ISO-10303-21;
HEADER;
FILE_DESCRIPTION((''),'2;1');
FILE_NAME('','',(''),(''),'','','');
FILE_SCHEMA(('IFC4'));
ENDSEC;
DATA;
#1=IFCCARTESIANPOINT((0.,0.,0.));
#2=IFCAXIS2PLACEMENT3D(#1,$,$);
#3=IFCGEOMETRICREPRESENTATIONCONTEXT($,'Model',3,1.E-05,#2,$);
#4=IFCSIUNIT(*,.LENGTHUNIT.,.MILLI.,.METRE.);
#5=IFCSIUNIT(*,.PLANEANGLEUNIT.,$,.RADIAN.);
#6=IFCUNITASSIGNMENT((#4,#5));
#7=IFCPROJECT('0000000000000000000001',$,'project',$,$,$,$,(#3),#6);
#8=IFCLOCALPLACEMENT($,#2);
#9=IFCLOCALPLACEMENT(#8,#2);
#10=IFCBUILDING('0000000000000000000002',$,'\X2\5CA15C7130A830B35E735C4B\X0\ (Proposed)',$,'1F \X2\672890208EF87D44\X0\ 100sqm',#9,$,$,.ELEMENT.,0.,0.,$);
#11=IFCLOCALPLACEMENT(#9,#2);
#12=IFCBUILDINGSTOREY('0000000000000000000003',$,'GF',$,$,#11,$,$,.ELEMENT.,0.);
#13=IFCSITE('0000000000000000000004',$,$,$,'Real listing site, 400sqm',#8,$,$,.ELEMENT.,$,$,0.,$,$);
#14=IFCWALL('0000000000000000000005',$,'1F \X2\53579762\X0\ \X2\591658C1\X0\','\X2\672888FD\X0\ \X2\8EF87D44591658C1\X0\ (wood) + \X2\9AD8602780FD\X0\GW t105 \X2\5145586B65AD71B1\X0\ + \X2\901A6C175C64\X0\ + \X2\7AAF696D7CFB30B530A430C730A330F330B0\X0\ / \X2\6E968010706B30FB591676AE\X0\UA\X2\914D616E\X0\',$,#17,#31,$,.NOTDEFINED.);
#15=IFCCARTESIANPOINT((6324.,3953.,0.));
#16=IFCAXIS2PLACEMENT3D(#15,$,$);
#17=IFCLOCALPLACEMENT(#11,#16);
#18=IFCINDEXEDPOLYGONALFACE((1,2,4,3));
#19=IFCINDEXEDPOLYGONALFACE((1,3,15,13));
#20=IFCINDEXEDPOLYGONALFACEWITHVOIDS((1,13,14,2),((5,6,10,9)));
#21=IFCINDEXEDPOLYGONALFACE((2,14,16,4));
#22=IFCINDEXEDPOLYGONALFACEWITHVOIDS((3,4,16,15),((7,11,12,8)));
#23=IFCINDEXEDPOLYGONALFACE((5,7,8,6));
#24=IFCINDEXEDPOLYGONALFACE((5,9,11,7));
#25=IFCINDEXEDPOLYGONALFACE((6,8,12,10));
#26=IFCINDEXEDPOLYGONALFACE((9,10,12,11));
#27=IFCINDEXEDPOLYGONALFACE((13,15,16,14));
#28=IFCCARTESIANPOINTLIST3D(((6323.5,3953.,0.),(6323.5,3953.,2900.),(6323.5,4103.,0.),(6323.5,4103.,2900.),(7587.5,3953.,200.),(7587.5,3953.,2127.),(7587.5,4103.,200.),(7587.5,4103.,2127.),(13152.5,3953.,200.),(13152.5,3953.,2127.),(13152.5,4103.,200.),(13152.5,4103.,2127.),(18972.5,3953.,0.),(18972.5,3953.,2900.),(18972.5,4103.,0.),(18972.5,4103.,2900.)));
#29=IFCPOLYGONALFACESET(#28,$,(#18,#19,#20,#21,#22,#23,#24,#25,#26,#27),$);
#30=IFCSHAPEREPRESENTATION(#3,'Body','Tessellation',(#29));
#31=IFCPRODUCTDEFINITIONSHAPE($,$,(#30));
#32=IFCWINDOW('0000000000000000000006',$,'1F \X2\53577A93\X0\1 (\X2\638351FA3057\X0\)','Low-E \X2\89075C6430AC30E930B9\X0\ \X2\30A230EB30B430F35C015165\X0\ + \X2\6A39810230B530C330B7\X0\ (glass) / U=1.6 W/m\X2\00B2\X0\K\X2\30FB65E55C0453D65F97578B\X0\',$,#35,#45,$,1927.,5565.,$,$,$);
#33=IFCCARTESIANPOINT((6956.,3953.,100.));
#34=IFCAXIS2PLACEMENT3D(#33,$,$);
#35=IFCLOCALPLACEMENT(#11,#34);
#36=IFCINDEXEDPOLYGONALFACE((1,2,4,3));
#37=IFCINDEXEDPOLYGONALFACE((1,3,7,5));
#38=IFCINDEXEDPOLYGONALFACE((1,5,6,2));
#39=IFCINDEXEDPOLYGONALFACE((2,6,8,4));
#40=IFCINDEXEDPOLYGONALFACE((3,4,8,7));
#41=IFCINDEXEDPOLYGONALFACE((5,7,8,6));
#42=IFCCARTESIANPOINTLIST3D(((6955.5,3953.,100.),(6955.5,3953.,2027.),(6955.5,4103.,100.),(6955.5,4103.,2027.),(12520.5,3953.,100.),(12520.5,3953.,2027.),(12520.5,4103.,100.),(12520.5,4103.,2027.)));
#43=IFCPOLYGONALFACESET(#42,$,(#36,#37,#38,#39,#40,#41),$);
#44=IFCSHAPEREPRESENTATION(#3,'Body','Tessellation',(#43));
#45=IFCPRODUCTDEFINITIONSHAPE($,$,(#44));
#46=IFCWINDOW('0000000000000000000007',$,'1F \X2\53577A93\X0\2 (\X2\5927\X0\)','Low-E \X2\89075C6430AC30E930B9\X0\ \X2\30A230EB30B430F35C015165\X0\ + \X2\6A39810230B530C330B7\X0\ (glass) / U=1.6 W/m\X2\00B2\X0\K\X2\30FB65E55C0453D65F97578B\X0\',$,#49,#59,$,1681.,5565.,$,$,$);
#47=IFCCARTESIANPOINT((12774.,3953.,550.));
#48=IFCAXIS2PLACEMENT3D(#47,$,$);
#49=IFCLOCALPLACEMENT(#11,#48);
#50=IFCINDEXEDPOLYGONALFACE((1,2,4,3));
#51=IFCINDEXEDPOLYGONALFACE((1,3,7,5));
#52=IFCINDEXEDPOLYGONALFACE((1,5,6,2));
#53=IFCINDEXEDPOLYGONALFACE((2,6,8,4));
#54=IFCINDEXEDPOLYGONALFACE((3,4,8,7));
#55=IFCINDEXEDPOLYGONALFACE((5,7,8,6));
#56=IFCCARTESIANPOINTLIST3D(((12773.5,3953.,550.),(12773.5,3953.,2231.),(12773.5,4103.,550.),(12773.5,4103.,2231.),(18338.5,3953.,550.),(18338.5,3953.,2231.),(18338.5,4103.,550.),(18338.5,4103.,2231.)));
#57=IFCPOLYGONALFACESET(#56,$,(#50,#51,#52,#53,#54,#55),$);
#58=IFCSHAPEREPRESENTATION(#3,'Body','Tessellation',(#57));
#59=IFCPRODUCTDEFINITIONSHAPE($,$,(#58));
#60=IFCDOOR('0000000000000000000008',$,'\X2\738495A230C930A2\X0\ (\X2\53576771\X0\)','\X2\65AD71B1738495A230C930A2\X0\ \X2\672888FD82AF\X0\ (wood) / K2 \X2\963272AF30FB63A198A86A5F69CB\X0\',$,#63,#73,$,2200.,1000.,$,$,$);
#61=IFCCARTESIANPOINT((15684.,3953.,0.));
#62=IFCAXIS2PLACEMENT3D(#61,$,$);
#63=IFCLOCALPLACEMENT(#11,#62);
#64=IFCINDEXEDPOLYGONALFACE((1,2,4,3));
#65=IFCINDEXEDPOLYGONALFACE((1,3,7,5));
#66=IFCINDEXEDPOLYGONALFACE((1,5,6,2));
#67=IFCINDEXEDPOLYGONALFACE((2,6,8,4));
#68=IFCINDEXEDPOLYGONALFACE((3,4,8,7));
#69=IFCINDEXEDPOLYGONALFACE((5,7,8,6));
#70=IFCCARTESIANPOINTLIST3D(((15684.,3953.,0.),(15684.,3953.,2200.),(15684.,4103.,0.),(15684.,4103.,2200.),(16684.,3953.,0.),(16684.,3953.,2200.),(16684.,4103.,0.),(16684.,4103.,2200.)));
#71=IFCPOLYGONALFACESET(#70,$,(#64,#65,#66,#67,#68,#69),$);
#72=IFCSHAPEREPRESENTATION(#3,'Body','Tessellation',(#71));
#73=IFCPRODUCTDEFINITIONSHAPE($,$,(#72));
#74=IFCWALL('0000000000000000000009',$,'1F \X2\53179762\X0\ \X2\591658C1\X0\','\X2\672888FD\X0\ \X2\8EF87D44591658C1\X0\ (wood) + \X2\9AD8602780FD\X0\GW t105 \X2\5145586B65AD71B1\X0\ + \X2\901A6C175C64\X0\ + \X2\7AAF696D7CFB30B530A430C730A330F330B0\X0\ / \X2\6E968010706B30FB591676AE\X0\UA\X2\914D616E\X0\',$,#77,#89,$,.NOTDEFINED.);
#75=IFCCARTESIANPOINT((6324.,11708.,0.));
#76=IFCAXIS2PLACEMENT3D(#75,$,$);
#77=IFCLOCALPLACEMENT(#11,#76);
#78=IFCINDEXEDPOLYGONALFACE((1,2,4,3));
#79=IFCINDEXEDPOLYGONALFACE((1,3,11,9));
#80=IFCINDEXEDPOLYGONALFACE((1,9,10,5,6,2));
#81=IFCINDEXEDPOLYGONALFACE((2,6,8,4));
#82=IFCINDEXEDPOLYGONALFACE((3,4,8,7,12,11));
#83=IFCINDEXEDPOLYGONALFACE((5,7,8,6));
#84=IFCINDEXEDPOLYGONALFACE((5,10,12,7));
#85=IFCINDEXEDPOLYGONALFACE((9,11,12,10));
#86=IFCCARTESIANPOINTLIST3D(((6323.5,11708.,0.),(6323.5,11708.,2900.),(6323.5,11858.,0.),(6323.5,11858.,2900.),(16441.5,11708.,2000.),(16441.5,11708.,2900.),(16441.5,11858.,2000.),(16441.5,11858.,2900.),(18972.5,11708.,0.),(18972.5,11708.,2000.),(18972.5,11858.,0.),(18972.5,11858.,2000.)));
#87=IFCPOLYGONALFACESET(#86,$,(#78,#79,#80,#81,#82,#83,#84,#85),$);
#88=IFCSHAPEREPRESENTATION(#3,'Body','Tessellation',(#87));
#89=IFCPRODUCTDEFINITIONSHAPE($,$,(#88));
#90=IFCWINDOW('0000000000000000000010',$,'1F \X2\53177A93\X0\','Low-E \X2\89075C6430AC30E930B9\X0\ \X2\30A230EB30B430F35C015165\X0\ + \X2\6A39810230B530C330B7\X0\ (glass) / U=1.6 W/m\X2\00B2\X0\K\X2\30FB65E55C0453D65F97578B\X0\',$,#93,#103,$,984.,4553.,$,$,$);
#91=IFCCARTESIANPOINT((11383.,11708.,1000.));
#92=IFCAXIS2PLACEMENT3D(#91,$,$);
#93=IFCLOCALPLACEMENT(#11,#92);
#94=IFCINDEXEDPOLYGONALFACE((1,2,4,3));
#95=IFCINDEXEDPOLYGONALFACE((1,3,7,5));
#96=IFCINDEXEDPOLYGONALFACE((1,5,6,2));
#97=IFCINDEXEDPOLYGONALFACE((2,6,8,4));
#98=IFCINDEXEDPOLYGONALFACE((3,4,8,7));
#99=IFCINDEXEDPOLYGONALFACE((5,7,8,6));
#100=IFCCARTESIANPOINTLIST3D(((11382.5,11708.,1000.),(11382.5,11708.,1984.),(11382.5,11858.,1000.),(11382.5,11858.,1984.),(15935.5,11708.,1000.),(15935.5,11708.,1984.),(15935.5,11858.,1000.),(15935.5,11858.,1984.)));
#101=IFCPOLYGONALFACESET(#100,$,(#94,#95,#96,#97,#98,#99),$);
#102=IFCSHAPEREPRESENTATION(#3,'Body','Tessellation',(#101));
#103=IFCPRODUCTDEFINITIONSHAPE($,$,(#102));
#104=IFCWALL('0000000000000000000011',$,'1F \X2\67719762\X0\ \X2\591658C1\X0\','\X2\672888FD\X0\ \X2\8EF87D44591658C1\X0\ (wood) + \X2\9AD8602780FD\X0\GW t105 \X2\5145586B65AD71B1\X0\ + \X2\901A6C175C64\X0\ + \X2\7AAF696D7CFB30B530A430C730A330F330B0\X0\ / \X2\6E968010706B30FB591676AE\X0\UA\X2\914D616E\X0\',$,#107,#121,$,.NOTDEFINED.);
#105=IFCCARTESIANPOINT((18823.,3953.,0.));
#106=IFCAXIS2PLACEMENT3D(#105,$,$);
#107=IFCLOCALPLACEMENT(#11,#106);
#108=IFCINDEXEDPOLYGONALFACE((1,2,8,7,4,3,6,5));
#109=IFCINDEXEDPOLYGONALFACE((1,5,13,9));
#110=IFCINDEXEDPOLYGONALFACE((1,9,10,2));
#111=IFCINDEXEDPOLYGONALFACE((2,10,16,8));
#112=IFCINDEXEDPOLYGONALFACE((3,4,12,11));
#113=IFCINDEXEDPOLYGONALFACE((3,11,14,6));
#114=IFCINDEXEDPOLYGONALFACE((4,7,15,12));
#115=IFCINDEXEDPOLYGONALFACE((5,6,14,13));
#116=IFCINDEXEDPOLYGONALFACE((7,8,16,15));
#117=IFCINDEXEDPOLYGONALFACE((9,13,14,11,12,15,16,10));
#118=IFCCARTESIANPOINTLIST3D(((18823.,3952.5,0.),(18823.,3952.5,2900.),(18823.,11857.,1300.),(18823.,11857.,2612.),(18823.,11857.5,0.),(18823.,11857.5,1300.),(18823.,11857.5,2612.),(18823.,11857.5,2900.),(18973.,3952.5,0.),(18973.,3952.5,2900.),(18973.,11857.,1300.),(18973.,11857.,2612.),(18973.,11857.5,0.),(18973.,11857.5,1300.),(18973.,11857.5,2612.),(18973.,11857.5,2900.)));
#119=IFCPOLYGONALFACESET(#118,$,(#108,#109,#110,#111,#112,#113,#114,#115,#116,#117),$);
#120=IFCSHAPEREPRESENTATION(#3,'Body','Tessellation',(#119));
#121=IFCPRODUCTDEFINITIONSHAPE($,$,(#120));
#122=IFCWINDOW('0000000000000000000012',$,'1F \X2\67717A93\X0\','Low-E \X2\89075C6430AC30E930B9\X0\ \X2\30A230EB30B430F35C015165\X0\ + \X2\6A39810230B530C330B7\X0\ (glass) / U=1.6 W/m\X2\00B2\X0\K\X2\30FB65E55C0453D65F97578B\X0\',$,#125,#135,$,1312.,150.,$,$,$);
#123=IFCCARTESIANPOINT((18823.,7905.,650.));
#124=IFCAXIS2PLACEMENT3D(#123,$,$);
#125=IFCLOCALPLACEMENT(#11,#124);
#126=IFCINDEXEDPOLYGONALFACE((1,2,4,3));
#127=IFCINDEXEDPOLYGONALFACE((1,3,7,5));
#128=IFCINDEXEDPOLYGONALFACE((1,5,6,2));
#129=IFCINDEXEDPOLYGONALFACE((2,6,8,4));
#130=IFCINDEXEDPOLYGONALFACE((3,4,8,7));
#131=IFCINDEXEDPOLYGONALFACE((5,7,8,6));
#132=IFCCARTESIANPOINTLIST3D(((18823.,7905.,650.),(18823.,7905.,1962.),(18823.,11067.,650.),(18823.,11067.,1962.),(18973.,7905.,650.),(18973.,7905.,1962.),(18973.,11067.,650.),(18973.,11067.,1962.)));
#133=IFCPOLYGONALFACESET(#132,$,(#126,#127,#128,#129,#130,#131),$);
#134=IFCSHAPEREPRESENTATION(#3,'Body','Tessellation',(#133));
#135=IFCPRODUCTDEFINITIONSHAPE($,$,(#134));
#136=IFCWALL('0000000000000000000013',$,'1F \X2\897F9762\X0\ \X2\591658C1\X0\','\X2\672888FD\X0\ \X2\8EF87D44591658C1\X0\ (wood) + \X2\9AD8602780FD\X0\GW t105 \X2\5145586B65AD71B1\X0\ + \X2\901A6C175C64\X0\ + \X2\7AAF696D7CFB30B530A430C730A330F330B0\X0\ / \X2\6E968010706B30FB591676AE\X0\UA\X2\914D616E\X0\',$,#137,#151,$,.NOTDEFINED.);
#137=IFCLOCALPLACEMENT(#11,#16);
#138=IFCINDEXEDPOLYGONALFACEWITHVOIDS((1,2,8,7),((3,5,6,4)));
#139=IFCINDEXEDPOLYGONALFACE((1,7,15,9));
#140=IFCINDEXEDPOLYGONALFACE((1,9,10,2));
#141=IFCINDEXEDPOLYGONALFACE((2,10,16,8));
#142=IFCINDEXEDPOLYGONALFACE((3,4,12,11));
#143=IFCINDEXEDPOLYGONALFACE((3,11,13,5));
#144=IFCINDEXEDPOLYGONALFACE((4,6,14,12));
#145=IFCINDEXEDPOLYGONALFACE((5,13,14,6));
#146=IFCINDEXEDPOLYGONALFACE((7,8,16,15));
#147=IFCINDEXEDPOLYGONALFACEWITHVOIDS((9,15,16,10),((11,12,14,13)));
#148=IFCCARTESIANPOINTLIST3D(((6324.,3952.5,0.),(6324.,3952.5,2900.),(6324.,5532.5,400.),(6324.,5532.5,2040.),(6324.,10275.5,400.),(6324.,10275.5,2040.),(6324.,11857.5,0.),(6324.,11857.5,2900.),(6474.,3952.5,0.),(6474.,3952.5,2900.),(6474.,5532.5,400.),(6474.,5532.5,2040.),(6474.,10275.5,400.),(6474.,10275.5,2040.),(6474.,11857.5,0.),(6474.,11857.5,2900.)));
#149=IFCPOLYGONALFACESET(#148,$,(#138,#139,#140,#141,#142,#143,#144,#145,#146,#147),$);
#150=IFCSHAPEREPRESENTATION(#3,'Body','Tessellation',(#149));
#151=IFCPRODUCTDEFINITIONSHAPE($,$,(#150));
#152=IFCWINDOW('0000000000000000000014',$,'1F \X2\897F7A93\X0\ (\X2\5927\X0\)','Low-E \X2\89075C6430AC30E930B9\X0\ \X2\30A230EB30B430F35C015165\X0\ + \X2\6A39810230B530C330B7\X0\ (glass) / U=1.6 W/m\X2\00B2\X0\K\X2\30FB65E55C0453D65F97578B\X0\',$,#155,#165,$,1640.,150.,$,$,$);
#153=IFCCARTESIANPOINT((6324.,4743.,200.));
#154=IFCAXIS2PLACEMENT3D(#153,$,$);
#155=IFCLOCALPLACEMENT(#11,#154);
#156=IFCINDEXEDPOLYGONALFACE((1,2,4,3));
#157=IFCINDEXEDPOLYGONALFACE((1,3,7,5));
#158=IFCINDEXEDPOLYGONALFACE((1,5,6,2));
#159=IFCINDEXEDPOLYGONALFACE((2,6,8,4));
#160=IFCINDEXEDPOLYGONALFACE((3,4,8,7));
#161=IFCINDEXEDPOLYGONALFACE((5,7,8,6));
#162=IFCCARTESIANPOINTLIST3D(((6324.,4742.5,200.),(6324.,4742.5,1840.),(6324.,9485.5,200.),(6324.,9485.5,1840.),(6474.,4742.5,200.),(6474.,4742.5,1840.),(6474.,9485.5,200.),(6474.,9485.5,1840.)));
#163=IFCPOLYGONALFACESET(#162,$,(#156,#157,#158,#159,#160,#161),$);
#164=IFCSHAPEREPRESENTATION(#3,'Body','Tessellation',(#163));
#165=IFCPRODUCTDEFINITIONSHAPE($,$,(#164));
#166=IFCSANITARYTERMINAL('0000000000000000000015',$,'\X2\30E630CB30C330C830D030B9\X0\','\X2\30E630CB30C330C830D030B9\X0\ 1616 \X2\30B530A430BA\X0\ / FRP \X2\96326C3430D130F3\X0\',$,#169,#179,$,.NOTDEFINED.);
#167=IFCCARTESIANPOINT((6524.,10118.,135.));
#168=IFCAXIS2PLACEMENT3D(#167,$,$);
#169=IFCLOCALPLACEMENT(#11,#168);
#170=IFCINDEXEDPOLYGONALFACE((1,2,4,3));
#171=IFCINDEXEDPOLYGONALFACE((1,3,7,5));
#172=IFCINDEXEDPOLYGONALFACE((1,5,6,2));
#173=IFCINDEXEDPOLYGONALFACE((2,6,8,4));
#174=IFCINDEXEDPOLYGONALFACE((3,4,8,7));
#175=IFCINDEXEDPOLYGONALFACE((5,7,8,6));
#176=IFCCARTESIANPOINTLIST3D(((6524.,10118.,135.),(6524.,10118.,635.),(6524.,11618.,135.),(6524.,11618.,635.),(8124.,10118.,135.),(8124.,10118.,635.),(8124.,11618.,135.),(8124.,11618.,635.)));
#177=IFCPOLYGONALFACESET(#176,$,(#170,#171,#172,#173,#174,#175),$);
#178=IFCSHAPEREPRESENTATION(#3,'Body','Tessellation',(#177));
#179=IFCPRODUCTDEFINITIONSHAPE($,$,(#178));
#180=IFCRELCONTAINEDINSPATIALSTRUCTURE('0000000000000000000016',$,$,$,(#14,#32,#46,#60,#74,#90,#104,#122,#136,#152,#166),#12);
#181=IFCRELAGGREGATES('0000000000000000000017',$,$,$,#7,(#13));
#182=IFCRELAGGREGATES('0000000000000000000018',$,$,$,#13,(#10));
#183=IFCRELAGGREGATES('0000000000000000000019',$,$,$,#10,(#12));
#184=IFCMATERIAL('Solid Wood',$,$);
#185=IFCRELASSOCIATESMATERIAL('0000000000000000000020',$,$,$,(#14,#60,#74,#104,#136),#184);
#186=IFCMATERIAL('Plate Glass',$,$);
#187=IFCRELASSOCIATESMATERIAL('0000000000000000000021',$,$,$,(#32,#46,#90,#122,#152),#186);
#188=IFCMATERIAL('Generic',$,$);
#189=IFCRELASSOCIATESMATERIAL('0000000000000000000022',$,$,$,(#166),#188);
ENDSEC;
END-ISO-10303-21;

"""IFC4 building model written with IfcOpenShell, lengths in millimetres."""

from ifc_helpers import new_model, si_unit, frame, frame_2d, origin, place, context, project, spatial, rectangle, extrude, material, element, fill, save


model = new_model("IFC4")

# Units and contexts
model_context = context("Model", 3, precision=1e-05, world=origin())
ifc_project = project(units=[si_unit("LENGTHUNIT", "METRE", prefix="MILLI"), si_unit("PLANEANGLEUNIT", "RADIAN")], contexts=[model_context])

# Site, building, storey
site_placement = place(None, origin())
site = spatial("IfcSite", under=ifc_project, at=site_placement, ObjectType="Real listing site, 400sqm", CompositionType="ELEMENT", RefElevation=0.0)
building_placement = place(site_placement, origin())
building = spatial("IfcBuilding", under=site, at=building_placement, Name="岡山エコ平屋 (Proposed)", ObjectType="1F 木造軸組 100sqm", CompositionType="ELEMENT", ElevationOfRefHeight=0.0, ElevationOfTerrain=0.0)
storey_placement = place(building_placement, origin())
storey = spatial("IfcBuildingStorey", under=building, at=storey_placement, Name="GF", CompositionType="ELEMENT", Elevation=0.0)

# Shared definitions
ifc_material_1 = material(Name="Solid Wood")

# Wall, openings, windows, door
wall_1_placement = place(storey_placement, frame((6324.0, 3953.0, 0.0)))
wall_1 = element("IfcWall", 1, at=wall_1_placement, inside=storey, material=ifc_material_1, Name="1F 南面 外壁", Description="木製 軸組外壁 (wood) + 高性能GW t105 充填断熱 + 通気層 + 窯業系サイディング / 準耐火・外皮UA配慮", PredefinedType="NOTDEFINED", context=model_context, shape_type="SweptSolid", body=[
    extrude(rectangle(XDim=12649.0, YDim=150.0, at=frame_2d((6324.0, 75.0))), frame((6324.0, 3953.0, 0.0)), (0.0, 0.0, 1.0), 2900.0),
])
opening_1_placement = place(storey_placement, frame((6956.0, 3953.0, 100.0)))
opening_1 = element("IfcOpeningElement", 2, at=opening_1_placement, cuts=wall_1, PredefinedType="NOTDEFINED", context=model_context, shape_type="SweptSolid", body=[
    extrude(rectangle(XDim=5565.0, YDim=150.0, at=frame_2d((2782.0, 75.0))), frame((6956.0, 3953.0, 100.0)), (0.0, 0.0, 1.0), 1927.0),
])
opening_2_placement = place(storey_placement, frame((12774.0, 3953.0, 550.0)))
opening_2 = element("IfcOpeningElement", 3, at=opening_2_placement, cuts=wall_1, PredefinedType="NOTDEFINED", context=model_context, shape_type="SweptSolid", body=[
    extrude(rectangle(XDim=5565.0, YDim=150.0, at=frame_2d((2782.0, 75.0))), frame((12774.0, 3953.0, 550.0)), (0.0, 0.0, 1.0), 1681.0),
])
opening_3_placement = place(storey_placement, frame((15684.0, 3953.0, 0.0)))
opening_3 = element("IfcOpeningElement", 4, at=opening_3_placement, cuts=wall_1, PredefinedType="NOTDEFINED", context=model_context, shape_type="SweptSolid", body=[
    extrude(rectangle(XDim=1000.0, YDim=150.0, at=frame_2d((500.0, 75.0))), frame((15684.0, 3953.0, 0.0)), (0.0, 0.0, 1.0), 2200.0),
])
ifc_material_2 = material(Name="Plate Glass")
window_1_placement = place(storey_placement, frame((6956.0, 3953.0, 100.0)))
window_1 = element("IfcWindow", 5, at=window_1_placement, inside=storey, material=ifc_material_2, Name="1F 南窓1 (掃出し)", Description="Low-E 複層ガラス アルゴン封入 + 樹脂サッシ (glass) / U=1.6 W/m²K・日射取得型", OverallHeight=1927.0, OverallWidth=5565.0, context=model_context, shape_type="SweptSolid", body=[
    extrude(rectangle(XDim=5565.0, YDim=150.0, at=frame_2d((2782.0, 75.0))), frame((6956.0, 3953.0, 100.0)), (0.0, 0.0, 1.0), 1927.0),
])
fill(opening_1, window_1)
window_2_placement = place(storey_placement, frame((12774.0, 3953.0, 550.0)))
window_2 = element("IfcWindow", 6, at=window_2_placement, inside=storey, material=ifc_material_2, Name="1F 南窓2 (大)", Description="Low-E 複層ガラス アルゴン封入 + 樹脂サッシ (glass) / U=1.6 W/m²K・日射取得型", OverallHeight=1681.0, OverallWidth=5565.0, context=model_context, shape_type="SweptSolid", body=[
    extrude(rectangle(XDim=5565.0, YDim=150.0, at=frame_2d((2782.0, 75.0))), frame((12774.0, 3953.0, 550.0)), (0.0, 0.0, 1.0), 1681.0),
])
fill(opening_2, window_2)
door_placement = place(storey_placement, frame((15684.0, 3953.0, 0.0)))
door = element("IfcDoor", 7, at=door_placement, inside=storey, material=ifc_material_1, Name="玄関ドア (南東)", Description="断熱玄関ドア 木製芯 (wood) / K2 防犯・採風機構", OverallHeight=2200.0, OverallWidth=1000.0, context=model_context, shape_type="SweptSolid", body=[
    extrude(rectangle(XDim=1000.0, YDim=150.0, at=frame_2d((500.0, 75.0))), frame((15684.0, 3953.0, 0.0)), (0.0, 0.0, 1.0), 2200.0),
])
fill(opening_3, door)

# Walls, openings, windows
wall_2_placement = place(storey_placement, frame((6324.0, 11708.0, 0.0)))
wall_2 = element("IfcWall", 8, at=wall_2_placement, inside=storey, material=ifc_material_1, Name="1F 北面 外壁", Description="木製 軸組外壁 (wood) + 高性能GW t105 充填断熱 + 通気層 + 窯業系サイディング / 準耐火・外皮UA配慮", PredefinedType="NOTDEFINED", context=model_context, shape_type="SweptSolid", body=[
    extrude(rectangle(XDim=12649.0, YDim=150.0, at=frame_2d((6324.0, 75.0))), frame((6324.0, 11708.0, 0.0)), (0.0, 0.0, 1.0), 2900.0),
])
opening_4_placement = place(storey_placement, frame((11383.0, 11708.0, 1000.0)))
opening_4 = element("IfcOpeningElement", 9, at=opening_4_placement, cuts=wall_2, PredefinedType="NOTDEFINED", context=model_context, shape_type="SweptSolid", body=[
    extrude(rectangle(XDim=4553.0, YDim=150.0, at=frame_2d((2276.0, 75.0))), frame((11383.0, 11708.0, 1000.0)), (0.0, 0.0, 1.0), 984.0),
])
window_3_placement = place(storey_placement, frame((11383.0, 11708.0, 1000.0)))
window_3 = element("IfcWindow", 10, at=window_3_placement, inside=storey, material=ifc_material_2, Name="1F 北窓", Description="Low-E 複層ガラス アルゴン封入 + 樹脂サッシ (glass) / U=1.6 W/m²K・日射取得型", OverallHeight=984.0, OverallWidth=4553.0, context=model_context, shape_type="SweptSolid", body=[
    extrude(rectangle(XDim=4553.0, YDim=150.0, at=frame_2d((2276.0, 75.0))), frame((11383.0, 11708.0, 1000.0)), (0.0, 0.0, 1.0), 984.0),
])
fill(opening_4, window_3)
wall_3_placement = place(storey_placement, frame((18823.0, 3953.0, 0.0)))
wall_3 = element("IfcWall", 11, at=wall_3_placement, inside=storey, material=ifc_material_1, Name="1F 東面 外壁", Description="木製 軸組外壁 (wood) + 高性能GW t105 充填断熱 + 通気層 + 窯業系サイディング / 準耐火・外皮UA配慮", PredefinedType="NOTDEFINED", context=model_context, shape_type="SweptSolid", body=[
    extrude(rectangle(XDim=150.0, YDim=7905.0, at=frame_2d((75.0, 3952.0))), frame((18823.0, 3953.0, 0.0)), (0.0, 0.0, 1.0), 2900.0),
])
opening_5_placement = place(storey_placement, frame((18823.0, 7905.0, 650.0)))
opening_5 = element("IfcOpeningElement", 12, at=opening_5_placement, cuts=wall_3, PredefinedType="NOTDEFINED", context=model_context, shape_type="SweptSolid", body=[
    extrude(rectangle(XDim=150.0, YDim=3162.0, at=frame_2d((75.0, 1581.0))), frame((18823.0, 7905.0, 650.0)), (0.0, 0.0, 1.0), 1312.0),
])
window_4_placement = place(storey_placement, frame((18823.0, 7905.0, 650.0)))
window_4 = element("IfcWindow", 13, at=window_4_placement, inside=storey, material=ifc_material_2, Name="1F 東窓", Description="Low-E 複層ガラス アルゴン封入 + 樹脂サッシ (glass) / U=1.6 W/m²K・日射取得型", OverallHeight=1312.0, OverallWidth=150.0, context=model_context, shape_type="SweptSolid", body=[
    extrude(rectangle(XDim=150.0, YDim=3162.0, at=frame_2d((75.0, 1581.0))), frame((18823.0, 7905.0, 650.0)), (0.0, 0.0, 1.0), 1312.0),
])
fill(opening_5, window_4)
wall_4_placement = place(storey_placement, frame((6324.0, 3953.0, 0.0)))
wall_4 = element("IfcWall", 14, at=wall_4_placement, inside=storey, material=ifc_material_1, Name="1F 西面 外壁", Description="木製 軸組外壁 (wood) + 高性能GW t105 充填断熱 + 通気層 + 窯業系サイディング / 準耐火・外皮UA配慮", PredefinedType="NOTDEFINED", context=model_context, shape_type="SweptSolid", body=[
    extrude(rectangle(XDim=150.0, YDim=7905.0, at=frame_2d((75.0, 3952.0))), frame((6324.0, 3953.0, 0.0)), (0.0, 0.0, 1.0), 2900.0),
])
opening_6_placement = place(storey_placement, frame((6324.0, 4743.0, 200.0)))
opening_6 = element("IfcOpeningElement", 15, at=opening_6_placement, cuts=wall_4, PredefinedType="NOTDEFINED", context=model_context, shape_type="SweptSolid", body=[
    extrude(rectangle(XDim=150.0, YDim=4743.0, at=frame_2d((75.0, 2371.0))), frame((6324.0, 4743.0, 200.0)), (0.0, 0.0, 1.0), 1640.0),
])
window_5_placement = place(storey_placement, frame((6324.0, 4743.0, 200.0)))
window_5 = element("IfcWindow", 16, at=window_5_placement, inside=storey, material=ifc_material_2, Name="1F 西窓 (大)", Description="Low-E 複層ガラス アルゴン封入 + 樹脂サッシ (glass) / U=1.6 W/m²K・日射取得型", OverallHeight=1640.0, OverallWidth=150.0, context=model_context, shape_type="SweptSolid", body=[
    extrude(rectangle(XDim=150.0, YDim=4743.0, at=frame_2d((75.0, 2371.0))), frame((6324.0, 4743.0, 200.0)), (0.0, 0.0, 1.0), 1640.0),
])
fill(opening_6, window_5)

# Shared definitions
ifc_material_3 = material(Name="Generic")

# Sanitary terminal
sanitary_terminal_1_placement = place(storey_placement, frame((6524.0, 10118.0, 135.0)))
element("IfcSanitaryTerminal", 17, at=sanitary_terminal_1_placement, inside=storey, material=ifc_material_3, Name="ユニットバス", Description="ユニットバス 1616 サイズ / FRP 防水パン", PredefinedType="NOTDEFINED", context=model_context, shape_type="SweptSolid", body=[
    extrude(rectangle(XDim=1600.0, YDim=1500.0, at=frame_2d((800.0, 750.0))), frame((6524.0, 10118.0, 135.0)), (0.0, 0.0, 1.0), 500.0),
])

save(model, "model.ifc")
